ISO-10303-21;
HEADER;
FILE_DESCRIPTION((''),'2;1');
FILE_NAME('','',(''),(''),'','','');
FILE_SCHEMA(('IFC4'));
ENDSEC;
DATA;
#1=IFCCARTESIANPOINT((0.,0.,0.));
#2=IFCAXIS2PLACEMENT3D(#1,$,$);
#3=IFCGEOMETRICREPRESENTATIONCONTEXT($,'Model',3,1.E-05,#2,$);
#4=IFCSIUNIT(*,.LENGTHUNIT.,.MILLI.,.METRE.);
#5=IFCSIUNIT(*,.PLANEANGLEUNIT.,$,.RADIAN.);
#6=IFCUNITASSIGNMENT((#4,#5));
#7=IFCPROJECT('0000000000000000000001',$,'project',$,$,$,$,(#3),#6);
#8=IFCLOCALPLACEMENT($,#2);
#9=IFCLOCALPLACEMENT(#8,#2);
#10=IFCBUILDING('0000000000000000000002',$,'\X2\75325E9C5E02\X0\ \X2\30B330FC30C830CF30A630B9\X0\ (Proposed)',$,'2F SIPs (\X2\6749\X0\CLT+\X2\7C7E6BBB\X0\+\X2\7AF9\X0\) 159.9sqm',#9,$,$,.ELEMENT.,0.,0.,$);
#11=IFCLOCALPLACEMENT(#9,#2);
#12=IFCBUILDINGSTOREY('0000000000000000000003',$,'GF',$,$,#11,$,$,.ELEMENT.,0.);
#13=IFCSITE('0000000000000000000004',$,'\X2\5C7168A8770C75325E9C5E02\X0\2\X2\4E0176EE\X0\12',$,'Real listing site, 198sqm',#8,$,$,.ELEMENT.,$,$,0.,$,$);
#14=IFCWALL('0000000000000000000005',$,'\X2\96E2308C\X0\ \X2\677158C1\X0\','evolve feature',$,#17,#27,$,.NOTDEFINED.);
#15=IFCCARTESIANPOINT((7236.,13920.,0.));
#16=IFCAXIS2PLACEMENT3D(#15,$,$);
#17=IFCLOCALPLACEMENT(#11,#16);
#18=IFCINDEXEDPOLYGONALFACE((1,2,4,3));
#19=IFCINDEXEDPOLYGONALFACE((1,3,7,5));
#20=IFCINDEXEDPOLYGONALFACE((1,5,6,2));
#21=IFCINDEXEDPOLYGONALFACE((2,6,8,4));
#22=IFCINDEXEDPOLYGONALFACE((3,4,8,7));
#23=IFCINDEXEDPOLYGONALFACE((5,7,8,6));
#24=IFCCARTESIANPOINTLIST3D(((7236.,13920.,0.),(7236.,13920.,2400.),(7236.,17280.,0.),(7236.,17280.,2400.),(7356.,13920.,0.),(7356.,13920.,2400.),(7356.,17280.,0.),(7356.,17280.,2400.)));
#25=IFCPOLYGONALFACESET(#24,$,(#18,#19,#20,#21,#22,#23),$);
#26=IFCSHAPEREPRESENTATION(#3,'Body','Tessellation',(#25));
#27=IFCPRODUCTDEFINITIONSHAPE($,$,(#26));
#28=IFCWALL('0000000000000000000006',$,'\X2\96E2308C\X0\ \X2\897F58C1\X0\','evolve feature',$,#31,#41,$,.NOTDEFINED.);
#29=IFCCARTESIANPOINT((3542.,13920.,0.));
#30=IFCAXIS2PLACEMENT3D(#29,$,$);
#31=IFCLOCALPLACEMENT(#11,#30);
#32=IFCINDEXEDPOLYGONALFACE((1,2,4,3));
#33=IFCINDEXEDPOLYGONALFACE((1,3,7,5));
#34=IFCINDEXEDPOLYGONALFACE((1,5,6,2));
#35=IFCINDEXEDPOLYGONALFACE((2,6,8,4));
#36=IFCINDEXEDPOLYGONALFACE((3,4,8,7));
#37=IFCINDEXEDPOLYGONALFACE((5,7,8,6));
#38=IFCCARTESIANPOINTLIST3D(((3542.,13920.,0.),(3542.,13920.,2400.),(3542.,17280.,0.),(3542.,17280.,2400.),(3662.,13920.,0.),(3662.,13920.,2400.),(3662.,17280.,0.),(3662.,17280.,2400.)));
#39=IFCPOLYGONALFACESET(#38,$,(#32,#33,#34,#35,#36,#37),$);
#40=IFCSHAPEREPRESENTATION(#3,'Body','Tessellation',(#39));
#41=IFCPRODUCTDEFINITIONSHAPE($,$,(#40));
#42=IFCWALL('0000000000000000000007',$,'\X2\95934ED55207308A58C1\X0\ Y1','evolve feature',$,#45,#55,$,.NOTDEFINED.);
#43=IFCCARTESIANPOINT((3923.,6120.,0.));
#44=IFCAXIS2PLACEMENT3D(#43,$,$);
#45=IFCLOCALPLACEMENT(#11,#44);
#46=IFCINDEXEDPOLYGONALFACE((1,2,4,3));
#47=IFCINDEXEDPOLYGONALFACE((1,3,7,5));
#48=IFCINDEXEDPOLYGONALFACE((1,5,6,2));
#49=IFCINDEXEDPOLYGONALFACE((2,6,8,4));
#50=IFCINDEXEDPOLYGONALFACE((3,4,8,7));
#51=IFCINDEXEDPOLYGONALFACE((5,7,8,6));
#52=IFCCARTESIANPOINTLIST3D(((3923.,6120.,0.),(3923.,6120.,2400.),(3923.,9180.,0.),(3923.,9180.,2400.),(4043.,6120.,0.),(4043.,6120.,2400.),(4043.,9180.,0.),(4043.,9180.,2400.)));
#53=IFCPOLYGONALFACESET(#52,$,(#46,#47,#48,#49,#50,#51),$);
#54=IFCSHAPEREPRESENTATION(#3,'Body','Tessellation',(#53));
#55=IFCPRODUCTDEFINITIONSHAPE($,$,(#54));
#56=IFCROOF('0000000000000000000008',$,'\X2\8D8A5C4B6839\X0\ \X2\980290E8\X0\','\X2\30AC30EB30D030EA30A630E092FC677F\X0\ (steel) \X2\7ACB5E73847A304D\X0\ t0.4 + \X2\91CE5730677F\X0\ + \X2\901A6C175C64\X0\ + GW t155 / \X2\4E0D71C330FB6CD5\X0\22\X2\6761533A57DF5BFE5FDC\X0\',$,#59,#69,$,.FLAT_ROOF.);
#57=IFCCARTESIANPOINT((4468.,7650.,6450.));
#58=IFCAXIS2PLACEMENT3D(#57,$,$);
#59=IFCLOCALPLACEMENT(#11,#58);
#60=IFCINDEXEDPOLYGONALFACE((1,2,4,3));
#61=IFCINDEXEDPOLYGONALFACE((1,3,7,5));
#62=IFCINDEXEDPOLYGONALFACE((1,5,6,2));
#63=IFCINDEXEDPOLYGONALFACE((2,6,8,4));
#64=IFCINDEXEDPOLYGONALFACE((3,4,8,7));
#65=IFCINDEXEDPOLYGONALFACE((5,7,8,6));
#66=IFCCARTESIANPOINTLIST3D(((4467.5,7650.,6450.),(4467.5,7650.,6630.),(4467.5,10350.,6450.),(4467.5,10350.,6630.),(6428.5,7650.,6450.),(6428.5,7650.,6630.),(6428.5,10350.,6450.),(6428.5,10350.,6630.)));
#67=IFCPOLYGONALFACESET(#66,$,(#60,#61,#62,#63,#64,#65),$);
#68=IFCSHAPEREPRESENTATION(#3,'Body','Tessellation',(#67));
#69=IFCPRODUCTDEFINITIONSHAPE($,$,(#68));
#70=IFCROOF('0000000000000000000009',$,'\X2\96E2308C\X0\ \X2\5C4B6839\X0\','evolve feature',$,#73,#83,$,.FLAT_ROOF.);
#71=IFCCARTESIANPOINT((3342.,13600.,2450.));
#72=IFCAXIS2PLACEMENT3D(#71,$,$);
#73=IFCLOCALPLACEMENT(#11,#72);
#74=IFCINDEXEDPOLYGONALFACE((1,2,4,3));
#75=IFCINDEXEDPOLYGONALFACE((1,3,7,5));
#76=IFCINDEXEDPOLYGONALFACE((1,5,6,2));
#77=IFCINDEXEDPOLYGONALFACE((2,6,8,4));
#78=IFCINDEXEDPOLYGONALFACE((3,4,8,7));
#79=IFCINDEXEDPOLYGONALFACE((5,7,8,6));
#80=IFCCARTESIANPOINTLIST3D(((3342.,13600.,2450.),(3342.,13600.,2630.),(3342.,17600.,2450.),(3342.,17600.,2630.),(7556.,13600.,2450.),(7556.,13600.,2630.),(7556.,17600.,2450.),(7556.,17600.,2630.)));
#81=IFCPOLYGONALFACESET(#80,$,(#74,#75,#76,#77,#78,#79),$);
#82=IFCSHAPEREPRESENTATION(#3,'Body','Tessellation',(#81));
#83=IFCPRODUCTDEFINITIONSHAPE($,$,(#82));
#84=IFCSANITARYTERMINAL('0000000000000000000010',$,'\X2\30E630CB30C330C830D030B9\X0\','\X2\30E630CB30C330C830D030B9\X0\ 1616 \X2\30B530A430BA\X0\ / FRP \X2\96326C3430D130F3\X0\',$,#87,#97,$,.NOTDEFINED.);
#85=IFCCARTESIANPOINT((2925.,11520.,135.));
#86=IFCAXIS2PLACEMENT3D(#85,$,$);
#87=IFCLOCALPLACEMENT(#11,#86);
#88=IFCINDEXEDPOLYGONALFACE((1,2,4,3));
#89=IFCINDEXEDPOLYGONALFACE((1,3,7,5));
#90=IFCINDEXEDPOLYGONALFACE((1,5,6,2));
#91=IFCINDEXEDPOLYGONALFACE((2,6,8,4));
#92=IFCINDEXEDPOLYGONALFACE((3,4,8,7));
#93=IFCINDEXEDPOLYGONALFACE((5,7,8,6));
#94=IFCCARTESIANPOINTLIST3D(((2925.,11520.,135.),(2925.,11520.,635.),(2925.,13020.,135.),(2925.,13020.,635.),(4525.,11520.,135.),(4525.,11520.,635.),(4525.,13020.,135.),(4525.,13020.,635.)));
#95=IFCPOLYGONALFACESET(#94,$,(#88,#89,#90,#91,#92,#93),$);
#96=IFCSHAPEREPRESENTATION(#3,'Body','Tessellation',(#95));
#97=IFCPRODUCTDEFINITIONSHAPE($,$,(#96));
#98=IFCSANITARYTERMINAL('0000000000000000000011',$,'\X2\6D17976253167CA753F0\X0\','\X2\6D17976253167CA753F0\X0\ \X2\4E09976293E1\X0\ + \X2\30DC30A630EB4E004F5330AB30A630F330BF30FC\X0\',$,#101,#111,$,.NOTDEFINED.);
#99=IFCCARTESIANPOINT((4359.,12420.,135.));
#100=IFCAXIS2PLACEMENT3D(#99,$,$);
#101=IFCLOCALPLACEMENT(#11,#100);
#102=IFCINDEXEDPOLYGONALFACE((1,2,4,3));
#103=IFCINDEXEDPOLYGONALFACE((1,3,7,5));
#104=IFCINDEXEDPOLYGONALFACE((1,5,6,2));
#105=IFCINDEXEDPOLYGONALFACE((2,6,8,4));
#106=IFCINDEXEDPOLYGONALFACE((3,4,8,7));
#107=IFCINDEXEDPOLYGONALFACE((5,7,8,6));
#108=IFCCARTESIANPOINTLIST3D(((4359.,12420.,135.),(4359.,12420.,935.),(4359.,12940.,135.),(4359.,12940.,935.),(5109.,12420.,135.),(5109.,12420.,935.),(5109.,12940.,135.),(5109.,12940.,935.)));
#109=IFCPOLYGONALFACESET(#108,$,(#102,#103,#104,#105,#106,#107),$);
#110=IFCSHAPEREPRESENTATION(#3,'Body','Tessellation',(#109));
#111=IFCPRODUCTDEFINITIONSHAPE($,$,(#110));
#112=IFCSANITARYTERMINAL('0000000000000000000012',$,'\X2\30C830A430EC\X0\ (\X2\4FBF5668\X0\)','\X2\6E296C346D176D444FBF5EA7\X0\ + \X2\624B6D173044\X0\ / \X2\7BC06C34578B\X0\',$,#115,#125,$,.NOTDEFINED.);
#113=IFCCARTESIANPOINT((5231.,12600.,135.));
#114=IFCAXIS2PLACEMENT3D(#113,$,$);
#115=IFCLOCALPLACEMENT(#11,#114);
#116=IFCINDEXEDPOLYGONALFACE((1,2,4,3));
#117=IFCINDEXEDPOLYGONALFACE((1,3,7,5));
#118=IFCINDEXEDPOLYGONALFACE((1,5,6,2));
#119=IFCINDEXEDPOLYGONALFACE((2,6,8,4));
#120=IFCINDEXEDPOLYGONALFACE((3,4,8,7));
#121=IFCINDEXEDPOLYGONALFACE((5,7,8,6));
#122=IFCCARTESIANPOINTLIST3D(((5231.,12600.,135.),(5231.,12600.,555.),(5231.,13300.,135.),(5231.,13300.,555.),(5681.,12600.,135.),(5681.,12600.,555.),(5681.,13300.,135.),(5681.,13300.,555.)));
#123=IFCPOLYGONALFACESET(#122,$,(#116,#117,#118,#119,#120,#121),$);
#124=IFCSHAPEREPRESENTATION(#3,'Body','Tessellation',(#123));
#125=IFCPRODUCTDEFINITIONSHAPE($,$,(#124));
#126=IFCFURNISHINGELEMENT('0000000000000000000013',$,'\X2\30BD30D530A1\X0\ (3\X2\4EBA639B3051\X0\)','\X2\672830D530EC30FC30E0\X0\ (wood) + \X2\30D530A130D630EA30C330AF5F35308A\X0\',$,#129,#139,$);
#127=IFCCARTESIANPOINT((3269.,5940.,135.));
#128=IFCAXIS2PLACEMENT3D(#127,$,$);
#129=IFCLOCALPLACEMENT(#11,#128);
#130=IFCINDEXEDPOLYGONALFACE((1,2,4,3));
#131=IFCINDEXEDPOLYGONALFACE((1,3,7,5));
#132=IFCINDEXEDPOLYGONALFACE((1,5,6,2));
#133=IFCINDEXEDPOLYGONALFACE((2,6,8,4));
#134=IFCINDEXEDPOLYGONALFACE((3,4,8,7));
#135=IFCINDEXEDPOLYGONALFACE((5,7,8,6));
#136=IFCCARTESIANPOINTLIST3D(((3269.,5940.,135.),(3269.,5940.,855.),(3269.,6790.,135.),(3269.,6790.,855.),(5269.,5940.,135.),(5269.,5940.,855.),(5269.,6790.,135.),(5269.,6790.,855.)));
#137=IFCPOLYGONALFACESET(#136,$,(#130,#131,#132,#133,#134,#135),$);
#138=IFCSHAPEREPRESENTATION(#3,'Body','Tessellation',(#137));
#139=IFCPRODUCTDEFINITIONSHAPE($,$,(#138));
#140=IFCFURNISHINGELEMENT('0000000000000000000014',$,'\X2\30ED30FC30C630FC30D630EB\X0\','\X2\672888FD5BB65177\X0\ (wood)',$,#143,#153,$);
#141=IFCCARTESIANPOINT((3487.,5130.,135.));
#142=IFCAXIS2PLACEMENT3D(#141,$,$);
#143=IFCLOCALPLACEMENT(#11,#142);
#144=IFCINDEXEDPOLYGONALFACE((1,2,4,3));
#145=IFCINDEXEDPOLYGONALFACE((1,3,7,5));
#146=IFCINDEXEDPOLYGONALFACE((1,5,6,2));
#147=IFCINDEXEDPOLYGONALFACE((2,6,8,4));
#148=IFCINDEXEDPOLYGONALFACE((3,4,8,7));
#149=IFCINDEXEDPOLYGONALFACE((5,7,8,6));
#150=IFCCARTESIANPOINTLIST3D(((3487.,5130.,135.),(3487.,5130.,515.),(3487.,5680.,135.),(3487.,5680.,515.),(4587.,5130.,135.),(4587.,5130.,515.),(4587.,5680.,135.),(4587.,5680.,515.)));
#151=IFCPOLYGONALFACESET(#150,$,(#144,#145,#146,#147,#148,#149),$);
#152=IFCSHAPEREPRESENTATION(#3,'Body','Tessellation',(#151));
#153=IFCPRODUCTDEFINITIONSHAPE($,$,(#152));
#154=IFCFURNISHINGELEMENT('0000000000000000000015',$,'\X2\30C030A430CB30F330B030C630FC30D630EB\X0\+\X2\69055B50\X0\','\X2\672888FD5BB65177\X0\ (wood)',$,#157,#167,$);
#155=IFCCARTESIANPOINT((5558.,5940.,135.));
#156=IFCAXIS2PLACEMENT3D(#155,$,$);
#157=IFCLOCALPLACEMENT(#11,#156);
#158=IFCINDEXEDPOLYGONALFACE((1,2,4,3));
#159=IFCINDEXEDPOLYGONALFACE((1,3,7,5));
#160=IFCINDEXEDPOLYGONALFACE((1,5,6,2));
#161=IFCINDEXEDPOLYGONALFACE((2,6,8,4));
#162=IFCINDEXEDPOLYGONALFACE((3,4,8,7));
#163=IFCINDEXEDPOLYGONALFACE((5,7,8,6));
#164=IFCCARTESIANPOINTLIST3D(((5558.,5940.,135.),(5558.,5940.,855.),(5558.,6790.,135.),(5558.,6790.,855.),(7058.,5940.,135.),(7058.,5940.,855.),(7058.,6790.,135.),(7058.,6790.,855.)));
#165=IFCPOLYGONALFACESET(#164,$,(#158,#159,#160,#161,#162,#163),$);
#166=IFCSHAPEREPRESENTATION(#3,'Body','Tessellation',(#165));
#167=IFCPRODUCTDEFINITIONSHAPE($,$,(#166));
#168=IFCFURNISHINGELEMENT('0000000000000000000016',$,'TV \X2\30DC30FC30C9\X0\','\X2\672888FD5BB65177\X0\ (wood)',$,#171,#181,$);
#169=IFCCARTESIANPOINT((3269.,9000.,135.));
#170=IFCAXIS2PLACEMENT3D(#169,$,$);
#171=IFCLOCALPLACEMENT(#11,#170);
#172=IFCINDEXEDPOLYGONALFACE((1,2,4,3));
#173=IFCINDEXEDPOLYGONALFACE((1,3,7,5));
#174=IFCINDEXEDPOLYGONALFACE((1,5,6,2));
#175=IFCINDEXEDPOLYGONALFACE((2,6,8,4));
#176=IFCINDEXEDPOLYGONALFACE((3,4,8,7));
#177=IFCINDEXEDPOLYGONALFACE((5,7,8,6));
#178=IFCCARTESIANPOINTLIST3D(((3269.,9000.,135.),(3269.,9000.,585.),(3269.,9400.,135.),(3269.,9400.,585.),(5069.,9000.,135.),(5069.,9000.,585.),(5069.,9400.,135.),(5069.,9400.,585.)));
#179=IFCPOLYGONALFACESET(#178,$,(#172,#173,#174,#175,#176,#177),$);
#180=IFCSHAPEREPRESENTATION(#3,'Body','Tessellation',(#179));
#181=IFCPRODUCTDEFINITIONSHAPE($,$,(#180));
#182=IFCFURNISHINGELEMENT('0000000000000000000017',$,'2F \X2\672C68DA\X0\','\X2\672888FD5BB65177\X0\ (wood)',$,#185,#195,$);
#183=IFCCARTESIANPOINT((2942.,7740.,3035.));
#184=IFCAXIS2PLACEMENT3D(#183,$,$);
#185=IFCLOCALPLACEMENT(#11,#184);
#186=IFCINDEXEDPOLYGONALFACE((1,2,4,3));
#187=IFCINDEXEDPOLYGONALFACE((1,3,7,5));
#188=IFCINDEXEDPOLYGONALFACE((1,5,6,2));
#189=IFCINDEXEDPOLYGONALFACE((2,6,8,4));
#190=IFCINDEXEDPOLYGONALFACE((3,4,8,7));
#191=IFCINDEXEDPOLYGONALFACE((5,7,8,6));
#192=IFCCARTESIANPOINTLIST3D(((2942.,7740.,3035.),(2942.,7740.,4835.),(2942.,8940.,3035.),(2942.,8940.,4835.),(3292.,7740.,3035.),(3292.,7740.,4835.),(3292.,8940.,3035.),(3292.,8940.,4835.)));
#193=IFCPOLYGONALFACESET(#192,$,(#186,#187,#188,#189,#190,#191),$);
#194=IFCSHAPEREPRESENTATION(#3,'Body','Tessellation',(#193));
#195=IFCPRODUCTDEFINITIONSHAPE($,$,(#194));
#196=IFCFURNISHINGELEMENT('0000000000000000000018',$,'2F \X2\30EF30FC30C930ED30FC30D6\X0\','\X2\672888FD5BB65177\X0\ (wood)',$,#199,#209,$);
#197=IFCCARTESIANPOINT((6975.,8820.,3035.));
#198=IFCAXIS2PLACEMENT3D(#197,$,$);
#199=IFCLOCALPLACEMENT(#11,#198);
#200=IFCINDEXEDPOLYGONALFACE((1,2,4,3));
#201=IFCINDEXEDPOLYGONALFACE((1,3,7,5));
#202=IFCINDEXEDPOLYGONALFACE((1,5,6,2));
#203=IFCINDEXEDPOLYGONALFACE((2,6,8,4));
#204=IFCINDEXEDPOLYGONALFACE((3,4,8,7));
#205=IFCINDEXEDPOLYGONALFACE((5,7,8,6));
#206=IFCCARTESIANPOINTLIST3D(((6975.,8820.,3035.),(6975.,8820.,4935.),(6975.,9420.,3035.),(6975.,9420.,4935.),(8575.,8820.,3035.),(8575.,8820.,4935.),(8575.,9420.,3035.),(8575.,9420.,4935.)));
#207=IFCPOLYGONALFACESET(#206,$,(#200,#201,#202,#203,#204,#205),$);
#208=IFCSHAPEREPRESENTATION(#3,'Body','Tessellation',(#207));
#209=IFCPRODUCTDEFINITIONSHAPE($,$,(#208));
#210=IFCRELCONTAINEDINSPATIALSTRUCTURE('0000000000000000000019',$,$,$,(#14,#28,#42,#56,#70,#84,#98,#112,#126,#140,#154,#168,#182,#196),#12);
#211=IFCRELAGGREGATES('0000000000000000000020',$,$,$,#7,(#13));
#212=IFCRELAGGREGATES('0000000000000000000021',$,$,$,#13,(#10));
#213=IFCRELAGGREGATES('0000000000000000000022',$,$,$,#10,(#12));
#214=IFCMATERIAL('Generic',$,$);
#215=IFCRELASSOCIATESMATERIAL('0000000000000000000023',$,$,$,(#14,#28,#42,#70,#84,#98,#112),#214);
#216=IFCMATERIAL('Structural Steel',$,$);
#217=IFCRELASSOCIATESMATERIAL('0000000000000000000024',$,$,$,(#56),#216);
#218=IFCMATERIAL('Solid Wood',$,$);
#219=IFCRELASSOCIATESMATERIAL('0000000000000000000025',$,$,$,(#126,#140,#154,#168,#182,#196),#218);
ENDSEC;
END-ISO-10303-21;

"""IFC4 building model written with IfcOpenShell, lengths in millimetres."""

from ifc_helpers import new_model, si_unit, frame, frame_2d, origin, place, context, project, spatial, rectangle, extrude, material, element, save


model = new_model("IFC4")

# Units and contexts
model_context = context("Model", 3, precision=1e-05, world=origin())
ifc_project = project(units=[si_unit("LENGTHUNIT", "METRE", prefix="MILLI"), si_unit("PLANEANGLEUNIT", "RADIAN")], contexts=[model_context])

# Site, building, storey
site_placement = place(None, origin())
site = spatial("IfcSite", under=ifc_project, at=site_placement, Name="山梨県甲府市2丁目12", ObjectType="Real listing site, 198sqm", CompositionType="ELEMENT", RefElevation=0.0)
building_placement = place(site_placement, origin())
building = spatial("IfcBuilding", under=site, at=building_placement, Name="甲府市 コートハウス (Proposed)", ObjectType="2F SIPs (杉CLT+籾殻+竹) 159.9sqm", CompositionType="ELEMENT", ElevationOfRefHeight=0.0, ElevationOfTerrain=0.0)
storey_placement = place(building_placement, origin())
storey = spatial("IfcBuildingStorey", under=building, at=storey_placement, Name="GF", CompositionType="ELEMENT", Elevation=0.0)

# Shared definitions
ifc_material_1 = material(Name="Generic")

# Shared definitions
ifc_material_2 = material(Name="Solid Wood")

# Walls
wall_1_placement = place(storey_placement, frame((7236.0, 13920.0, 0.0)))
element("IfcWall", 1, at=wall_1_placement, inside=storey, material=ifc_material_1, Name="離れ 東壁", Description="evolve feature", PredefinedType="NOTDEFINED", context=model_context, shape_type="SweptSolid", body=[
    extrude(rectangle(XDim=120.0, YDim=3360.0, at=frame_2d((60.0, 1680.0))), frame((7236.0, 13920.0, 0.0)), (0.0, 0.0, 1.0), 2400.0),
])
wall_2_placement = place(storey_placement, frame((3542.0, 13920.0, 0.0)))
element("IfcWall", 2, at=wall_2_placement, inside=storey, material=ifc_material_1, Name="離れ 西壁", Description="evolve feature", PredefinedType="NOTDEFINED", context=model_context, shape_type="SweptSolid", body=[
    extrude(rectangle(XDim=120.0, YDim=3360.0, at=frame_2d((60.0, 1680.0))), frame((3542.0, 13920.0, 0.0)), (0.0, 0.0, 1.0), 2400.0),
])
wall_3_placement = place(storey_placement, frame((3923.0, 6120.0, 0.0)))
element("IfcWall", 3, at=wall_3_placement, inside=storey, material=ifc_material_1, Name="間仕切り壁 Y1", Description="evolve feature", PredefinedType="NOTDEFINED", context=model_context, shape_type="SweptSolid", body=[
    extrude(rectangle(XDim=120.0, YDim=3060.0, at=frame_2d((60.0, 1530.0))), frame((3923.0, 6120.0, 0.0)), (0.0, 0.0, 1.0), 2400.0),
])

# Roofs
ifc_material_3 = material(Name="Structural Steel")
roof_1_placement = place(storey_placement, frame((4468.0, 7650.0, 6450.0)))
element("IfcRoof", 4, at=roof_1_placement, inside=storey, material=ifc_material_3, Name="越屋根 頂部", Description="ガルバリウム鋼板 (steel) 立平葺き t0.4 + 野地板 + 通気層 + GW t155 / 不燃・法22条区域対応", PredefinedType="FLAT_ROOF", context=model_context, shape_type="SweptSolid", body=[
    extrude(rectangle(XDim=1961.0, YDim=2700.0, at=frame_2d((980.0, 1350.0))), frame((4468.0, 7650.0, 6450.0)), (0.0, 0.0, 1.0), 180.0),
])
roof_2_placement = place(storey_placement, frame((3342.0, 13600.0, 2450.0)))
element("IfcRoof", 5, at=roof_2_placement, inside=storey, material=ifc_material_1, Name="離れ 屋根", Description="evolve feature", PredefinedType="FLAT_ROOF", context=model_context, shape_type="SweptSolid", body=[
    extrude(rectangle(XDim=4214.0, YDim=4000.0, at=frame_2d((2107.0, 2000.0))), frame((3342.0, 13600.0, 2450.0)), (0.0, 0.0, 1.0), 180.0),
])

# Sanitary terminals
sanitary_terminal_1_placement = place(storey_placement, frame((2925.0, 11520.0, 135.0)))
element("IfcSanitaryTerminal", 6, at=sanitary_terminal_1_placement, inside=storey, material=ifc_material_1, Name="ユニットバス", Description="ユニットバス 1616 サイズ / FRP 防水パン", PredefinedType="NOTDEFINED", context=model_context, shape_type="SweptSolid", body=[
    extrude(rectangle(XDim=1600.0, YDim=1500.0, at=frame_2d((800.0, 750.0))), frame((2925.0, 11520.0, 135.0)), (0.0, 0.0, 1.0), 500.0),
])
sanitary_terminal_2_placement = place(storey_placement, frame((4359.0, 12420.0, 135.0)))
element("IfcSanitaryTerminal", 7, at=sanitary_terminal_2_placement, inside=storey, material=ifc_material_1, Name="洗面化粧台", Description="洗面化粧台 三面鏡 + ボウル一体カウンター", PredefinedType="NOTDEFINED", context=model_context, shape_type="SweptSolid", body=[
    extrude(rectangle(XDim=750.0, YDim=520.0, at=frame_2d((375.0, 260.0))), frame((4359.0, 12420.0, 135.0)), (0.0, 0.0, 1.0), 800.0),
])
sanitary_terminal_3_placement = place(storey_placement, frame((5231.0, 12600.0, 135.0)))
element("IfcSanitaryTerminal", 8, at=sanitary_terminal_3_placement, inside=storey, material=ifc_material_1, Name="トイレ (便器)", Description="温水洗浄便座 + 手洗い / 節水型", PredefinedType="NOTDEFINED", context=model_context, shape_type="SweptSolid", body=[
    extrude(rectangle(XDim=450.0, YDim=700.0, at=frame_2d((225.0, 350.0))), frame((5231.0, 12600.0, 135.0)), (0.0, 0.0, 1.0), 420.0),
])

# Furnishing elements
furnishing_1_placement = place(storey_placement, frame((3269.0, 5940.0, 135.0)))
element("IfcFurnishingElement", 9, at=furnishing_1_placement, inside=storey, material=ifc_material_2, Name="ソファ (3人掛け)", Description="木フレーム (wood) + ファブリック張り", context=model_context, shape_type="SweptSolid", body=[
    extrude(rectangle(XDim=2000.0, YDim=850.0, at=frame_2d((1000.0, 425.0))), frame((3269.0, 5940.0, 135.0)), (0.0, 0.0, 1.0), 720.0),
])
furnishing_2_placement = place(storey_placement, frame((3487.0, 5130.0, 135.0)))
element("IfcFurnishingElement", 10, at=furnishing_2_placement, inside=storey, material=ifc_material_2, Name="ローテーブル", Description="木製家具 (wood)", context=model_context, shape_type="SweptSolid", body=[
    extrude(rectangle(XDim=1100.0, YDim=550.0, at=frame_2d((550.0, 275.0))), frame((3487.0, 5130.0, 135.0)), (0.0, 0.0, 1.0), 380.0),
])
furnishing_3_placement = place(storey_placement, frame((5558.0, 5940.0, 135.0)))
element("IfcFurnishingElement", 11, at=furnishing_3_placement, inside=storey, material=ifc_material_2, Name="ダイニングテーブル+椅子", Description="木製家具 (wood)", context=model_context, shape_type="SweptSolid", body=[
    extrude(rectangle(XDim=1500.0, YDim=850.0, at=frame_2d((750.0, 425.0))), frame((5558.0, 5940.0, 135.0)), (0.0, 0.0, 1.0), 720.0),
])
furnishing_4_placement = place(storey_placement, frame((3269.0, 9000.0, 135.0)))
element("IfcFurnishingElement", 12, at=furnishing_4_placement, inside=storey, material=ifc_material_2, Name="TV ボード", Description="木製家具 (wood)", context=model_context, shape_type="SweptSolid", body=[
    extrude(rectangle(XDim=1800.0, YDim=400.0, at=frame_2d((900.0, 200.0))), frame((3269.0, 9000.0, 135.0)), (0.0, 0.0, 1.0), 450.0),
])
furnishing_5_placement = place(storey_placement, frame((2942.0, 7740.0, 3035.0)))
element("IfcFurnishingElement", 13, at=furnishing_5_placement, inside=storey, material=ifc_material_2, Name="2F 本棚", Description="木製家具 (wood)", context=model_context, shape_type="SweptSolid", body=[
    extrude(rectangle(XDim=350.0, YDim=1200.0, at=frame_2d((175.0, 600.0))), frame((2942.0, 7740.0, 3035.0)), (0.0, 0.0, 1.0), 1800.0),
])
furnishing_6_placement = place(storey_placement, frame((6975.0, 8820.0, 3035.0)))
element("IfcFurnishingElement", 14, at=furnishing_6_placement, inside=storey, material=ifc_material_2, Name="2F ワードローブ", Description="木製家具 (wood)", context=model_context, shape_type="SweptSolid", body=[
    extrude(rectangle(XDim=1600.0, YDim=600.0, at=frame_2d((800.0, 300.0))), frame((6975.0, 8820.0, 3035.0)), (0.0, 0.0, 1.0), 1900.0),
])

save(model, "model.ifc")
